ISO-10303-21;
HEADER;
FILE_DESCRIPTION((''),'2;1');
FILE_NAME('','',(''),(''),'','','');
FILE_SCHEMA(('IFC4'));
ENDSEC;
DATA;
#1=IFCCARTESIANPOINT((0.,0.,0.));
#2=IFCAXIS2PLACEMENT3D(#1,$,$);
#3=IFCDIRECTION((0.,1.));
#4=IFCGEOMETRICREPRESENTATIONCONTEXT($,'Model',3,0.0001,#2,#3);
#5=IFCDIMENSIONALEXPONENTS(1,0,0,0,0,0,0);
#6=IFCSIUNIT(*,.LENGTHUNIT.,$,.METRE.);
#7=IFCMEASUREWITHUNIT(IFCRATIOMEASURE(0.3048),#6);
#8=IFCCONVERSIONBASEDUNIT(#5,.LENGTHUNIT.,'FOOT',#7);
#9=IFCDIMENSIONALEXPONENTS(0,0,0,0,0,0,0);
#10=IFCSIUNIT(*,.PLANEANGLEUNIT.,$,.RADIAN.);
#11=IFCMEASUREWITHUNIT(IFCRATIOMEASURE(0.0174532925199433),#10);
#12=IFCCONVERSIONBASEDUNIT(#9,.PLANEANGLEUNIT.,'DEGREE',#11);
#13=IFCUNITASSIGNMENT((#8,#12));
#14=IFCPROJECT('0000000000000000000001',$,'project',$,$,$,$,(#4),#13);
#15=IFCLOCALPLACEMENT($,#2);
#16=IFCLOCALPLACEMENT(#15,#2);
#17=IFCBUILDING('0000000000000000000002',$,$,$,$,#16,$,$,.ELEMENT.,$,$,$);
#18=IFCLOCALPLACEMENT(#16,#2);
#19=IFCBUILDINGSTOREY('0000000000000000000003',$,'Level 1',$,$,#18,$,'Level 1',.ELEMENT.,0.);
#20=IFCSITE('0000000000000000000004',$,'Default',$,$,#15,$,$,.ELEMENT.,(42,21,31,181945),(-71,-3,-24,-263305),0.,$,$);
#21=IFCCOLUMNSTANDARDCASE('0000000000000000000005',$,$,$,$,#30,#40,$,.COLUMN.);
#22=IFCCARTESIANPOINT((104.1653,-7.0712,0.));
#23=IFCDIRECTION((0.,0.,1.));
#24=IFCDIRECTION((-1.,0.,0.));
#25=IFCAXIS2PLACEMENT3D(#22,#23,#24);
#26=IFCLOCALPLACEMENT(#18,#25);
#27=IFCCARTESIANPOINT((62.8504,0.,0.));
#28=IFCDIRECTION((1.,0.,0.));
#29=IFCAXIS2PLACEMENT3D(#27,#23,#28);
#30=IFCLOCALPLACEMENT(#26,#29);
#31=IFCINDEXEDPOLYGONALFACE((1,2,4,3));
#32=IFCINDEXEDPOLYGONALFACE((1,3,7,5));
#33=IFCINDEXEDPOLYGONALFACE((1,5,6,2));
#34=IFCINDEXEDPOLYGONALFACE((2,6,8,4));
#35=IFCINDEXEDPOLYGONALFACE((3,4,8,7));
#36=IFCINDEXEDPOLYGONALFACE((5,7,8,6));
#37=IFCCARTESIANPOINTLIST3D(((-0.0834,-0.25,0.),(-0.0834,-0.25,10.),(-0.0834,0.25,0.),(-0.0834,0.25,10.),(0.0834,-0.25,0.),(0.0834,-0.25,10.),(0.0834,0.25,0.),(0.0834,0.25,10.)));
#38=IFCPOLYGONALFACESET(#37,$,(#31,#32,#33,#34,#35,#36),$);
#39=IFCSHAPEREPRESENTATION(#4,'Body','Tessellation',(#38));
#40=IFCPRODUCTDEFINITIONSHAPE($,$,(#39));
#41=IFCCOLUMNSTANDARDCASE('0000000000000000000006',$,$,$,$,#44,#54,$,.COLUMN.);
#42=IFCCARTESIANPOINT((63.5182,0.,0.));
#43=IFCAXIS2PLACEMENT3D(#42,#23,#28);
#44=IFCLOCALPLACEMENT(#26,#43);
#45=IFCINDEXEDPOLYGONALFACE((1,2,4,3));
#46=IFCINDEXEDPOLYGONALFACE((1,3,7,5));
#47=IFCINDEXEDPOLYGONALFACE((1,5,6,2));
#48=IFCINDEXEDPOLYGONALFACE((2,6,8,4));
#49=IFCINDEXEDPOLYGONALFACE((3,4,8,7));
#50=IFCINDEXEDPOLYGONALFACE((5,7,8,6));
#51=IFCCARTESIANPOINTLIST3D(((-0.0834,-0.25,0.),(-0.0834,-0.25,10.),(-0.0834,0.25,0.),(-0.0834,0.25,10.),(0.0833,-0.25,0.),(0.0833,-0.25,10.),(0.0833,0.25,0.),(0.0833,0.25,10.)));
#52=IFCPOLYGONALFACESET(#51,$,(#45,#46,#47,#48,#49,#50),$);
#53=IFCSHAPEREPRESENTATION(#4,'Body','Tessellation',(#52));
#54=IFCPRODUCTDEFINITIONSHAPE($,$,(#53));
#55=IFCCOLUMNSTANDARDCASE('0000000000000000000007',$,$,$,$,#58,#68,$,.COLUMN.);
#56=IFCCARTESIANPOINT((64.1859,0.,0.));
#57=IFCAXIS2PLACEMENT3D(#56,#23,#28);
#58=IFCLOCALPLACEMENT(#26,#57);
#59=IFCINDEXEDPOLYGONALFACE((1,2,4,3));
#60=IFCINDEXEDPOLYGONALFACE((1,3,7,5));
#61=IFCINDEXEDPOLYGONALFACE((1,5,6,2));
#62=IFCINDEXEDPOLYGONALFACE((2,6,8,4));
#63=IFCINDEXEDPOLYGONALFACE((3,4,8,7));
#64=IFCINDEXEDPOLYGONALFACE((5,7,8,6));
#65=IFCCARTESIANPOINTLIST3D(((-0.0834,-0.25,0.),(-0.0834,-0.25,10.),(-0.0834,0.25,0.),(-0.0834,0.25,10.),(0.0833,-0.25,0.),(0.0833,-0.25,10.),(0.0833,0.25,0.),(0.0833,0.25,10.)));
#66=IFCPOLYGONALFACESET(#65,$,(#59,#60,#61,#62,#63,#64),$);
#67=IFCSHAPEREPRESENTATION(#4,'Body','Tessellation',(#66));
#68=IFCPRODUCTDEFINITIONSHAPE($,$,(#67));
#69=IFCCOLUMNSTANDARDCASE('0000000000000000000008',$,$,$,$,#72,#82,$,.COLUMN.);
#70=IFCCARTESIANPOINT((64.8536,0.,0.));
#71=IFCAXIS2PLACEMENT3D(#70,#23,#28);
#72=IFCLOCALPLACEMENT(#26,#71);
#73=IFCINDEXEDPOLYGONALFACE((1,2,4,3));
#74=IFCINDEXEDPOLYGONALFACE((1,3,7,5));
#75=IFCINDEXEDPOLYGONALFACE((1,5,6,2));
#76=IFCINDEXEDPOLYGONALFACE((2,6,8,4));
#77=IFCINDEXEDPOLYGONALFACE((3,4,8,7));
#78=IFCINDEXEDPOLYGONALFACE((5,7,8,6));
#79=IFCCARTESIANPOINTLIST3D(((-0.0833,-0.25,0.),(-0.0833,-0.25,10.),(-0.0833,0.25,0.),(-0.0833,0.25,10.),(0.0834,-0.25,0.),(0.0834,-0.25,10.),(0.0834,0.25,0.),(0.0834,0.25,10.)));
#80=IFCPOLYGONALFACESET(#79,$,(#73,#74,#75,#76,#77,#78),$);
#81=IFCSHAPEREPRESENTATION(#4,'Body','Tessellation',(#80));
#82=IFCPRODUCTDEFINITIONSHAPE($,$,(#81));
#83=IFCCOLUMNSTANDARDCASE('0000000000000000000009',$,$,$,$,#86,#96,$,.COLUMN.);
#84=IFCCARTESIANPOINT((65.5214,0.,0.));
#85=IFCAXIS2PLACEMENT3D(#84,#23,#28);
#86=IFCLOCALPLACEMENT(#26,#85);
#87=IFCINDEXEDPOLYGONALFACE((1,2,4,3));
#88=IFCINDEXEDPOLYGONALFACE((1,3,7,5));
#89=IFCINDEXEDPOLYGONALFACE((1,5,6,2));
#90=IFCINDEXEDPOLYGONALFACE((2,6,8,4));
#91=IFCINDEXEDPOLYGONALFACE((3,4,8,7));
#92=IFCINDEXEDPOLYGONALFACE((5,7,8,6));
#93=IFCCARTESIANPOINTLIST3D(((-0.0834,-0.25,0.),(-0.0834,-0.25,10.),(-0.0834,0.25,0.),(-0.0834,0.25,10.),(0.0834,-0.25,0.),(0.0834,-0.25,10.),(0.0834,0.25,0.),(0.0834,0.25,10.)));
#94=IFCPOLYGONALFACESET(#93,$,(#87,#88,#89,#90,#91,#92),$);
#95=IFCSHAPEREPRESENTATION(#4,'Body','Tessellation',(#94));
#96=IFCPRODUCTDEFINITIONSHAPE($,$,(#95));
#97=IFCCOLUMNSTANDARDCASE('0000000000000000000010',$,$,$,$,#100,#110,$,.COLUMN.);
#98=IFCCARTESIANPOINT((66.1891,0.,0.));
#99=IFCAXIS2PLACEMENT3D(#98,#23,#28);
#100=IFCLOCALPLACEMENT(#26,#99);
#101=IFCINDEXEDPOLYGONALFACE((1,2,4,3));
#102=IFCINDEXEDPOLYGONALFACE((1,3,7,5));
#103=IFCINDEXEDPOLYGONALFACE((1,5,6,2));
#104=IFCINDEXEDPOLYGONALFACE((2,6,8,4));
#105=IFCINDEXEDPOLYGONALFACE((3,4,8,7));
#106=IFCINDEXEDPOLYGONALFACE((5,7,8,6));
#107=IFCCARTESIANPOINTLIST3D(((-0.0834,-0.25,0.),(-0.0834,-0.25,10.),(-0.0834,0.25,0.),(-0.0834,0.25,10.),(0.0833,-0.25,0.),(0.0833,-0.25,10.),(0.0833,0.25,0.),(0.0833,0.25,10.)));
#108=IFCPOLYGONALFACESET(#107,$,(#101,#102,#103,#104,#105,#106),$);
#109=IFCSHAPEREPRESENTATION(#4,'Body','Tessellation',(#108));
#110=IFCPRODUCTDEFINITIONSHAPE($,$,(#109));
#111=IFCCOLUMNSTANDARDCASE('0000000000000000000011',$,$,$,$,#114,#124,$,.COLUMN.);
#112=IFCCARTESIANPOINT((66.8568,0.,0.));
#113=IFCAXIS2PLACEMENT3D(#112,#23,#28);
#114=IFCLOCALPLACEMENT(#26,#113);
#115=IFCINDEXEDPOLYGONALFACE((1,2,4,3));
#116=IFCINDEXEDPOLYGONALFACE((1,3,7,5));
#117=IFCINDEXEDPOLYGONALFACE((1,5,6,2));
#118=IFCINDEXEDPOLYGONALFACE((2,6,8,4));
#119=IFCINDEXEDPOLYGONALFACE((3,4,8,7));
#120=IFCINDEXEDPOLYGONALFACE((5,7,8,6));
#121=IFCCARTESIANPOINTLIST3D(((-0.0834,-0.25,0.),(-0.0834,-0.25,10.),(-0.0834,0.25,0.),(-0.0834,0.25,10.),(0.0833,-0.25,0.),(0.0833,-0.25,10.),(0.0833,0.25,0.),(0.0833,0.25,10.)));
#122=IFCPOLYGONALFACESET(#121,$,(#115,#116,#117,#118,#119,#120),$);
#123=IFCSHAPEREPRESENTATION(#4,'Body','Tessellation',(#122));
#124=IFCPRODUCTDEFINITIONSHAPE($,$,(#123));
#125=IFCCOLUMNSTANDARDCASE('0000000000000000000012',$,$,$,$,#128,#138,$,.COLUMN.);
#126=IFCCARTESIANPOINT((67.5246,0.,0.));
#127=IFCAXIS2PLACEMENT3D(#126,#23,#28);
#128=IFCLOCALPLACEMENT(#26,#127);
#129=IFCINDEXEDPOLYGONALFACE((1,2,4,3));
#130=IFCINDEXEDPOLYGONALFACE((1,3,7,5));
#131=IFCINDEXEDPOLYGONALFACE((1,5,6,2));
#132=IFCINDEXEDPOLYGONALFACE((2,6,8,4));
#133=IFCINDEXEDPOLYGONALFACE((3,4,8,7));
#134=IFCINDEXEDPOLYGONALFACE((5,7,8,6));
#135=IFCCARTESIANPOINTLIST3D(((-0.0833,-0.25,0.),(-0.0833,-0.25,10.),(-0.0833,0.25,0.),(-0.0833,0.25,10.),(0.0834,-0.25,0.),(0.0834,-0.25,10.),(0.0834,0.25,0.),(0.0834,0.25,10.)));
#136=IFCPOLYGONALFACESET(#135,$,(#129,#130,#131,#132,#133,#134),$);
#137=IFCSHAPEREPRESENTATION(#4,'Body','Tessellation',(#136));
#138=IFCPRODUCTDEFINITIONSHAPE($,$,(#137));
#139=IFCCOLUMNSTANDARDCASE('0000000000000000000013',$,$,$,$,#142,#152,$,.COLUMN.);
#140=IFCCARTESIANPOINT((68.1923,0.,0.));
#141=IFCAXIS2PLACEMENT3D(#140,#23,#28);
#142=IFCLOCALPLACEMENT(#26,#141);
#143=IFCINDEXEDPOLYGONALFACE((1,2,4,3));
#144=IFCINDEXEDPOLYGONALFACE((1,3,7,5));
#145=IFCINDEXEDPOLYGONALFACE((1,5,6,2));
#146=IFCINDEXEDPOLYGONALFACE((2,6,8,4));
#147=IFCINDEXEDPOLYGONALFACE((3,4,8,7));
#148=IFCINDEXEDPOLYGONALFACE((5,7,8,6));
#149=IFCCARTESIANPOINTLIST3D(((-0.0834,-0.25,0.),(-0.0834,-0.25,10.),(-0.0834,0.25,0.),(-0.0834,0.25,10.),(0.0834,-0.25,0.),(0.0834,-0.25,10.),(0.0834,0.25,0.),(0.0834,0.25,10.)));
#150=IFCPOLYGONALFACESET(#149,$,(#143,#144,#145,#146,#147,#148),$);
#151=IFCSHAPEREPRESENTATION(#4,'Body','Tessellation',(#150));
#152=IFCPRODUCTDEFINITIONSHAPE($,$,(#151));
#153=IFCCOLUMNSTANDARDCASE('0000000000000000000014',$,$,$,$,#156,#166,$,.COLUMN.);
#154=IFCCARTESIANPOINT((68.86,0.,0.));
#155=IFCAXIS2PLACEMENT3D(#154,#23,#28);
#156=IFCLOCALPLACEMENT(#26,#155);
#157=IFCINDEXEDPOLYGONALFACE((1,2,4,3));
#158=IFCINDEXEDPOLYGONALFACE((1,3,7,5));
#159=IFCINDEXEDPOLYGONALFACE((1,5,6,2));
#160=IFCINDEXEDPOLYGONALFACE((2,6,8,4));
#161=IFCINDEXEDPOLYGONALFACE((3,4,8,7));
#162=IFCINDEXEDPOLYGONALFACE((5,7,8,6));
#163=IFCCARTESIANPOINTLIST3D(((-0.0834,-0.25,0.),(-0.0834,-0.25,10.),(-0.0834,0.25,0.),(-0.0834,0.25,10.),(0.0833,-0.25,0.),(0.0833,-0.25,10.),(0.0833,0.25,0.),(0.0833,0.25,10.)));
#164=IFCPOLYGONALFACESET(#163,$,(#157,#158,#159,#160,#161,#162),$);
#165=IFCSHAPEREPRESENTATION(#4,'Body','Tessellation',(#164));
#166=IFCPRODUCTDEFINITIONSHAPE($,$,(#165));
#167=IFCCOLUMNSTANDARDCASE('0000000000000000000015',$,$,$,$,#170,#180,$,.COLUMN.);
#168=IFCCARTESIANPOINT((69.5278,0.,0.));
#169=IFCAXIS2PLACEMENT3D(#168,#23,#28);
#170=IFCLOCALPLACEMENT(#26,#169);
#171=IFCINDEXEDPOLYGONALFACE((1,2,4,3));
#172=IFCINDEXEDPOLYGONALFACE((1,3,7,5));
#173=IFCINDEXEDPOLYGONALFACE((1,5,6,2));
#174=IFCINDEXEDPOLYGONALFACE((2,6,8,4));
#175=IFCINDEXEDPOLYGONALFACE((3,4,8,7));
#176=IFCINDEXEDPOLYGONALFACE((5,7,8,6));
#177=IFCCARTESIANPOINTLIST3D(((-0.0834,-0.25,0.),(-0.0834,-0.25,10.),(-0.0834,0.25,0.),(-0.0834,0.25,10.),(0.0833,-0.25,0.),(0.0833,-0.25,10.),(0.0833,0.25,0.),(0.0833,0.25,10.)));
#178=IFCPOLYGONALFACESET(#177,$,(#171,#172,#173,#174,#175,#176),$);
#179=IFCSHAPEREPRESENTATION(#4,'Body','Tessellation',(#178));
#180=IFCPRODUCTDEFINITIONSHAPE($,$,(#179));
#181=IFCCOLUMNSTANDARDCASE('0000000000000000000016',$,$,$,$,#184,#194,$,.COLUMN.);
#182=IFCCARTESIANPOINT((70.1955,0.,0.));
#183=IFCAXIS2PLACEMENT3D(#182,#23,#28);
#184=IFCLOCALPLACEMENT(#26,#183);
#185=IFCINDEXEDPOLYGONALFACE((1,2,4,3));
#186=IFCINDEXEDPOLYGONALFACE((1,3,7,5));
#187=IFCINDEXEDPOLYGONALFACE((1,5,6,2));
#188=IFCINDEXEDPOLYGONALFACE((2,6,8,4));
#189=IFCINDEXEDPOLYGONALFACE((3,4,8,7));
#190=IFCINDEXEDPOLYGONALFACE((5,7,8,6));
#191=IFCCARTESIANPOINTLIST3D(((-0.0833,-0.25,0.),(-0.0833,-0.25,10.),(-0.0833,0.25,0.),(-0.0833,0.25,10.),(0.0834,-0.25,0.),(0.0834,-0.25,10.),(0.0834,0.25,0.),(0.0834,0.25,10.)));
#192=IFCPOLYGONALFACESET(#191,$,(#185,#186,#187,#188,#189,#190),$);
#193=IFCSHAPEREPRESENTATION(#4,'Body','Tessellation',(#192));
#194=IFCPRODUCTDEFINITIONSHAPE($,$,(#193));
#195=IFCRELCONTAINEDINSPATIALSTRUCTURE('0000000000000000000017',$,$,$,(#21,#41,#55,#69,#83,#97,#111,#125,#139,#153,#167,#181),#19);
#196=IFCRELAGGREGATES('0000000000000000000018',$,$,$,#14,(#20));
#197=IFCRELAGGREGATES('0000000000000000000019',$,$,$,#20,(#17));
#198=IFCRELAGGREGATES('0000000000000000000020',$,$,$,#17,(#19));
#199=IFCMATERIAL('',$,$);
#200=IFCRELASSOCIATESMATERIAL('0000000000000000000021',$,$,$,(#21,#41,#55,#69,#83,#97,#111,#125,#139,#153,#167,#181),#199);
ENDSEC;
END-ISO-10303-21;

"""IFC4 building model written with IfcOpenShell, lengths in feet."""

from ifc_helpers import new_model, entity, si_unit, converted_unit, direction, frame, origin, place, context, project, spatial, rectangle, extrude, material, element, save


model = new_model("IFC4")

# Units and contexts
model_context = context("Model", 3, precision=0.0001, world=origin(), true_north=direction((0.0, 1.0)))
ifc_project = project(units=[converted_unit("LENGTHUNIT", "FOOT", entity("IfcRatioMeasure", 0.3048), si_unit("LENGTHUNIT", "METRE"), dimensions=[1, 0, 0, 0, 0, 0, 0]), converted_unit("PLANEANGLEUNIT", "DEGREE", entity("IfcRatioMeasure", 0.0174532925199433), si_unit("PLANEANGLEUNIT", "RADIAN"), dimensions=[0, 0, 0, 0, 0, 0, 0])], contexts=[model_context])

# Site, building, storey
site_placement = place(None, origin())
site = spatial("IfcSite", under=ifc_project, at=site_placement, Name="Default", CompositionType="ELEMENT", RefLatitude=(42, 21, 31, 181945), RefLongitude=(-71, -3, -24, -263305), RefElevation=0.0)
building_placement = place(site_placement, origin())
building = spatial("IfcBuilding", under=site, at=building_placement, CompositionType="ELEMENT")
storey_placement = place(building_placement, origin())
storey = spatial("IfcBuildingStorey", under=building, at=storey_placement, Name="Level 1", LongName="Level 1", CompositionType="ELEMENT", Elevation=0.0)

# Columns
ifc_material = material(Name="")
placement = place(storey_placement, frame((104.1653, -7.0712, 0.0), z_axis=(0.0, 0.0, 1.0), x_axis=(-1.0, 0.0, 0.0)))
for number, where, z_axis, x_axis in (
    (1, (62.8504, 0.0, 0.0), (0.0, 0.0, 1.0), (1.0, 0.0, 0.0)),
    (2, (63.5182, 0.0, 0.0), (0.0, 0.0, 1.0), (1.0, 0.0, 0.0)),
    (3, (64.1859, 0.0, 0.0), (0.0, 0.0, 1.0), (1.0, 0.0, 0.0)),
    (4, (64.8536, 0.0, 0.0), (0.0, 0.0, 1.0), (1.0, 0.0, 0.0)),
    (5, (65.5214, 0.0, 0.0), (0.0, 0.0, 1.0), (1.0, 0.0, 0.0)),
    (6, (66.1891, 0.0, 0.0), (0.0, 0.0, 1.0), (1.0, 0.0, 0.0)),
    (7, (66.8568, 0.0, 0.0), (0.0, 0.0, 1.0), (1.0, 0.0, 0.0)),
    (8, (67.5246, 0.0, 0.0), (0.0, 0.0, 1.0), (1.0, 0.0, 0.0)),
    (9, (68.1923, 0.0, 0.0), (0.0, 0.0, 1.0), (1.0, 0.0, 0.0)),
    (10, (68.86, 0.0, 0.0), (0.0, 0.0, 1.0), (1.0, 0.0, 0.0)),
    (11, (69.5278, 0.0, 0.0), (0.0, 0.0, 1.0), (1.0, 0.0, 0.0)),
    (12, (70.1955, 0.0, 0.0), (0.0, 0.0, 1.0), (1.0, 0.0, 0.0)),
):
    element("IfcColumnStandardCase", number, at=place(placement, frame(where, z_axis=z_axis, x_axis=x_axis)), inside=storey, material=ifc_material, PredefinedType="COLUMN", context=model_context, shape_type="SweptSolid", body=[
        extrude(rectangle(XDim=0.1667, YDim=0.5), origin(), (0.0, 0.0, 1.0), 10.0),
    ])

save(model, "model.ifc")
